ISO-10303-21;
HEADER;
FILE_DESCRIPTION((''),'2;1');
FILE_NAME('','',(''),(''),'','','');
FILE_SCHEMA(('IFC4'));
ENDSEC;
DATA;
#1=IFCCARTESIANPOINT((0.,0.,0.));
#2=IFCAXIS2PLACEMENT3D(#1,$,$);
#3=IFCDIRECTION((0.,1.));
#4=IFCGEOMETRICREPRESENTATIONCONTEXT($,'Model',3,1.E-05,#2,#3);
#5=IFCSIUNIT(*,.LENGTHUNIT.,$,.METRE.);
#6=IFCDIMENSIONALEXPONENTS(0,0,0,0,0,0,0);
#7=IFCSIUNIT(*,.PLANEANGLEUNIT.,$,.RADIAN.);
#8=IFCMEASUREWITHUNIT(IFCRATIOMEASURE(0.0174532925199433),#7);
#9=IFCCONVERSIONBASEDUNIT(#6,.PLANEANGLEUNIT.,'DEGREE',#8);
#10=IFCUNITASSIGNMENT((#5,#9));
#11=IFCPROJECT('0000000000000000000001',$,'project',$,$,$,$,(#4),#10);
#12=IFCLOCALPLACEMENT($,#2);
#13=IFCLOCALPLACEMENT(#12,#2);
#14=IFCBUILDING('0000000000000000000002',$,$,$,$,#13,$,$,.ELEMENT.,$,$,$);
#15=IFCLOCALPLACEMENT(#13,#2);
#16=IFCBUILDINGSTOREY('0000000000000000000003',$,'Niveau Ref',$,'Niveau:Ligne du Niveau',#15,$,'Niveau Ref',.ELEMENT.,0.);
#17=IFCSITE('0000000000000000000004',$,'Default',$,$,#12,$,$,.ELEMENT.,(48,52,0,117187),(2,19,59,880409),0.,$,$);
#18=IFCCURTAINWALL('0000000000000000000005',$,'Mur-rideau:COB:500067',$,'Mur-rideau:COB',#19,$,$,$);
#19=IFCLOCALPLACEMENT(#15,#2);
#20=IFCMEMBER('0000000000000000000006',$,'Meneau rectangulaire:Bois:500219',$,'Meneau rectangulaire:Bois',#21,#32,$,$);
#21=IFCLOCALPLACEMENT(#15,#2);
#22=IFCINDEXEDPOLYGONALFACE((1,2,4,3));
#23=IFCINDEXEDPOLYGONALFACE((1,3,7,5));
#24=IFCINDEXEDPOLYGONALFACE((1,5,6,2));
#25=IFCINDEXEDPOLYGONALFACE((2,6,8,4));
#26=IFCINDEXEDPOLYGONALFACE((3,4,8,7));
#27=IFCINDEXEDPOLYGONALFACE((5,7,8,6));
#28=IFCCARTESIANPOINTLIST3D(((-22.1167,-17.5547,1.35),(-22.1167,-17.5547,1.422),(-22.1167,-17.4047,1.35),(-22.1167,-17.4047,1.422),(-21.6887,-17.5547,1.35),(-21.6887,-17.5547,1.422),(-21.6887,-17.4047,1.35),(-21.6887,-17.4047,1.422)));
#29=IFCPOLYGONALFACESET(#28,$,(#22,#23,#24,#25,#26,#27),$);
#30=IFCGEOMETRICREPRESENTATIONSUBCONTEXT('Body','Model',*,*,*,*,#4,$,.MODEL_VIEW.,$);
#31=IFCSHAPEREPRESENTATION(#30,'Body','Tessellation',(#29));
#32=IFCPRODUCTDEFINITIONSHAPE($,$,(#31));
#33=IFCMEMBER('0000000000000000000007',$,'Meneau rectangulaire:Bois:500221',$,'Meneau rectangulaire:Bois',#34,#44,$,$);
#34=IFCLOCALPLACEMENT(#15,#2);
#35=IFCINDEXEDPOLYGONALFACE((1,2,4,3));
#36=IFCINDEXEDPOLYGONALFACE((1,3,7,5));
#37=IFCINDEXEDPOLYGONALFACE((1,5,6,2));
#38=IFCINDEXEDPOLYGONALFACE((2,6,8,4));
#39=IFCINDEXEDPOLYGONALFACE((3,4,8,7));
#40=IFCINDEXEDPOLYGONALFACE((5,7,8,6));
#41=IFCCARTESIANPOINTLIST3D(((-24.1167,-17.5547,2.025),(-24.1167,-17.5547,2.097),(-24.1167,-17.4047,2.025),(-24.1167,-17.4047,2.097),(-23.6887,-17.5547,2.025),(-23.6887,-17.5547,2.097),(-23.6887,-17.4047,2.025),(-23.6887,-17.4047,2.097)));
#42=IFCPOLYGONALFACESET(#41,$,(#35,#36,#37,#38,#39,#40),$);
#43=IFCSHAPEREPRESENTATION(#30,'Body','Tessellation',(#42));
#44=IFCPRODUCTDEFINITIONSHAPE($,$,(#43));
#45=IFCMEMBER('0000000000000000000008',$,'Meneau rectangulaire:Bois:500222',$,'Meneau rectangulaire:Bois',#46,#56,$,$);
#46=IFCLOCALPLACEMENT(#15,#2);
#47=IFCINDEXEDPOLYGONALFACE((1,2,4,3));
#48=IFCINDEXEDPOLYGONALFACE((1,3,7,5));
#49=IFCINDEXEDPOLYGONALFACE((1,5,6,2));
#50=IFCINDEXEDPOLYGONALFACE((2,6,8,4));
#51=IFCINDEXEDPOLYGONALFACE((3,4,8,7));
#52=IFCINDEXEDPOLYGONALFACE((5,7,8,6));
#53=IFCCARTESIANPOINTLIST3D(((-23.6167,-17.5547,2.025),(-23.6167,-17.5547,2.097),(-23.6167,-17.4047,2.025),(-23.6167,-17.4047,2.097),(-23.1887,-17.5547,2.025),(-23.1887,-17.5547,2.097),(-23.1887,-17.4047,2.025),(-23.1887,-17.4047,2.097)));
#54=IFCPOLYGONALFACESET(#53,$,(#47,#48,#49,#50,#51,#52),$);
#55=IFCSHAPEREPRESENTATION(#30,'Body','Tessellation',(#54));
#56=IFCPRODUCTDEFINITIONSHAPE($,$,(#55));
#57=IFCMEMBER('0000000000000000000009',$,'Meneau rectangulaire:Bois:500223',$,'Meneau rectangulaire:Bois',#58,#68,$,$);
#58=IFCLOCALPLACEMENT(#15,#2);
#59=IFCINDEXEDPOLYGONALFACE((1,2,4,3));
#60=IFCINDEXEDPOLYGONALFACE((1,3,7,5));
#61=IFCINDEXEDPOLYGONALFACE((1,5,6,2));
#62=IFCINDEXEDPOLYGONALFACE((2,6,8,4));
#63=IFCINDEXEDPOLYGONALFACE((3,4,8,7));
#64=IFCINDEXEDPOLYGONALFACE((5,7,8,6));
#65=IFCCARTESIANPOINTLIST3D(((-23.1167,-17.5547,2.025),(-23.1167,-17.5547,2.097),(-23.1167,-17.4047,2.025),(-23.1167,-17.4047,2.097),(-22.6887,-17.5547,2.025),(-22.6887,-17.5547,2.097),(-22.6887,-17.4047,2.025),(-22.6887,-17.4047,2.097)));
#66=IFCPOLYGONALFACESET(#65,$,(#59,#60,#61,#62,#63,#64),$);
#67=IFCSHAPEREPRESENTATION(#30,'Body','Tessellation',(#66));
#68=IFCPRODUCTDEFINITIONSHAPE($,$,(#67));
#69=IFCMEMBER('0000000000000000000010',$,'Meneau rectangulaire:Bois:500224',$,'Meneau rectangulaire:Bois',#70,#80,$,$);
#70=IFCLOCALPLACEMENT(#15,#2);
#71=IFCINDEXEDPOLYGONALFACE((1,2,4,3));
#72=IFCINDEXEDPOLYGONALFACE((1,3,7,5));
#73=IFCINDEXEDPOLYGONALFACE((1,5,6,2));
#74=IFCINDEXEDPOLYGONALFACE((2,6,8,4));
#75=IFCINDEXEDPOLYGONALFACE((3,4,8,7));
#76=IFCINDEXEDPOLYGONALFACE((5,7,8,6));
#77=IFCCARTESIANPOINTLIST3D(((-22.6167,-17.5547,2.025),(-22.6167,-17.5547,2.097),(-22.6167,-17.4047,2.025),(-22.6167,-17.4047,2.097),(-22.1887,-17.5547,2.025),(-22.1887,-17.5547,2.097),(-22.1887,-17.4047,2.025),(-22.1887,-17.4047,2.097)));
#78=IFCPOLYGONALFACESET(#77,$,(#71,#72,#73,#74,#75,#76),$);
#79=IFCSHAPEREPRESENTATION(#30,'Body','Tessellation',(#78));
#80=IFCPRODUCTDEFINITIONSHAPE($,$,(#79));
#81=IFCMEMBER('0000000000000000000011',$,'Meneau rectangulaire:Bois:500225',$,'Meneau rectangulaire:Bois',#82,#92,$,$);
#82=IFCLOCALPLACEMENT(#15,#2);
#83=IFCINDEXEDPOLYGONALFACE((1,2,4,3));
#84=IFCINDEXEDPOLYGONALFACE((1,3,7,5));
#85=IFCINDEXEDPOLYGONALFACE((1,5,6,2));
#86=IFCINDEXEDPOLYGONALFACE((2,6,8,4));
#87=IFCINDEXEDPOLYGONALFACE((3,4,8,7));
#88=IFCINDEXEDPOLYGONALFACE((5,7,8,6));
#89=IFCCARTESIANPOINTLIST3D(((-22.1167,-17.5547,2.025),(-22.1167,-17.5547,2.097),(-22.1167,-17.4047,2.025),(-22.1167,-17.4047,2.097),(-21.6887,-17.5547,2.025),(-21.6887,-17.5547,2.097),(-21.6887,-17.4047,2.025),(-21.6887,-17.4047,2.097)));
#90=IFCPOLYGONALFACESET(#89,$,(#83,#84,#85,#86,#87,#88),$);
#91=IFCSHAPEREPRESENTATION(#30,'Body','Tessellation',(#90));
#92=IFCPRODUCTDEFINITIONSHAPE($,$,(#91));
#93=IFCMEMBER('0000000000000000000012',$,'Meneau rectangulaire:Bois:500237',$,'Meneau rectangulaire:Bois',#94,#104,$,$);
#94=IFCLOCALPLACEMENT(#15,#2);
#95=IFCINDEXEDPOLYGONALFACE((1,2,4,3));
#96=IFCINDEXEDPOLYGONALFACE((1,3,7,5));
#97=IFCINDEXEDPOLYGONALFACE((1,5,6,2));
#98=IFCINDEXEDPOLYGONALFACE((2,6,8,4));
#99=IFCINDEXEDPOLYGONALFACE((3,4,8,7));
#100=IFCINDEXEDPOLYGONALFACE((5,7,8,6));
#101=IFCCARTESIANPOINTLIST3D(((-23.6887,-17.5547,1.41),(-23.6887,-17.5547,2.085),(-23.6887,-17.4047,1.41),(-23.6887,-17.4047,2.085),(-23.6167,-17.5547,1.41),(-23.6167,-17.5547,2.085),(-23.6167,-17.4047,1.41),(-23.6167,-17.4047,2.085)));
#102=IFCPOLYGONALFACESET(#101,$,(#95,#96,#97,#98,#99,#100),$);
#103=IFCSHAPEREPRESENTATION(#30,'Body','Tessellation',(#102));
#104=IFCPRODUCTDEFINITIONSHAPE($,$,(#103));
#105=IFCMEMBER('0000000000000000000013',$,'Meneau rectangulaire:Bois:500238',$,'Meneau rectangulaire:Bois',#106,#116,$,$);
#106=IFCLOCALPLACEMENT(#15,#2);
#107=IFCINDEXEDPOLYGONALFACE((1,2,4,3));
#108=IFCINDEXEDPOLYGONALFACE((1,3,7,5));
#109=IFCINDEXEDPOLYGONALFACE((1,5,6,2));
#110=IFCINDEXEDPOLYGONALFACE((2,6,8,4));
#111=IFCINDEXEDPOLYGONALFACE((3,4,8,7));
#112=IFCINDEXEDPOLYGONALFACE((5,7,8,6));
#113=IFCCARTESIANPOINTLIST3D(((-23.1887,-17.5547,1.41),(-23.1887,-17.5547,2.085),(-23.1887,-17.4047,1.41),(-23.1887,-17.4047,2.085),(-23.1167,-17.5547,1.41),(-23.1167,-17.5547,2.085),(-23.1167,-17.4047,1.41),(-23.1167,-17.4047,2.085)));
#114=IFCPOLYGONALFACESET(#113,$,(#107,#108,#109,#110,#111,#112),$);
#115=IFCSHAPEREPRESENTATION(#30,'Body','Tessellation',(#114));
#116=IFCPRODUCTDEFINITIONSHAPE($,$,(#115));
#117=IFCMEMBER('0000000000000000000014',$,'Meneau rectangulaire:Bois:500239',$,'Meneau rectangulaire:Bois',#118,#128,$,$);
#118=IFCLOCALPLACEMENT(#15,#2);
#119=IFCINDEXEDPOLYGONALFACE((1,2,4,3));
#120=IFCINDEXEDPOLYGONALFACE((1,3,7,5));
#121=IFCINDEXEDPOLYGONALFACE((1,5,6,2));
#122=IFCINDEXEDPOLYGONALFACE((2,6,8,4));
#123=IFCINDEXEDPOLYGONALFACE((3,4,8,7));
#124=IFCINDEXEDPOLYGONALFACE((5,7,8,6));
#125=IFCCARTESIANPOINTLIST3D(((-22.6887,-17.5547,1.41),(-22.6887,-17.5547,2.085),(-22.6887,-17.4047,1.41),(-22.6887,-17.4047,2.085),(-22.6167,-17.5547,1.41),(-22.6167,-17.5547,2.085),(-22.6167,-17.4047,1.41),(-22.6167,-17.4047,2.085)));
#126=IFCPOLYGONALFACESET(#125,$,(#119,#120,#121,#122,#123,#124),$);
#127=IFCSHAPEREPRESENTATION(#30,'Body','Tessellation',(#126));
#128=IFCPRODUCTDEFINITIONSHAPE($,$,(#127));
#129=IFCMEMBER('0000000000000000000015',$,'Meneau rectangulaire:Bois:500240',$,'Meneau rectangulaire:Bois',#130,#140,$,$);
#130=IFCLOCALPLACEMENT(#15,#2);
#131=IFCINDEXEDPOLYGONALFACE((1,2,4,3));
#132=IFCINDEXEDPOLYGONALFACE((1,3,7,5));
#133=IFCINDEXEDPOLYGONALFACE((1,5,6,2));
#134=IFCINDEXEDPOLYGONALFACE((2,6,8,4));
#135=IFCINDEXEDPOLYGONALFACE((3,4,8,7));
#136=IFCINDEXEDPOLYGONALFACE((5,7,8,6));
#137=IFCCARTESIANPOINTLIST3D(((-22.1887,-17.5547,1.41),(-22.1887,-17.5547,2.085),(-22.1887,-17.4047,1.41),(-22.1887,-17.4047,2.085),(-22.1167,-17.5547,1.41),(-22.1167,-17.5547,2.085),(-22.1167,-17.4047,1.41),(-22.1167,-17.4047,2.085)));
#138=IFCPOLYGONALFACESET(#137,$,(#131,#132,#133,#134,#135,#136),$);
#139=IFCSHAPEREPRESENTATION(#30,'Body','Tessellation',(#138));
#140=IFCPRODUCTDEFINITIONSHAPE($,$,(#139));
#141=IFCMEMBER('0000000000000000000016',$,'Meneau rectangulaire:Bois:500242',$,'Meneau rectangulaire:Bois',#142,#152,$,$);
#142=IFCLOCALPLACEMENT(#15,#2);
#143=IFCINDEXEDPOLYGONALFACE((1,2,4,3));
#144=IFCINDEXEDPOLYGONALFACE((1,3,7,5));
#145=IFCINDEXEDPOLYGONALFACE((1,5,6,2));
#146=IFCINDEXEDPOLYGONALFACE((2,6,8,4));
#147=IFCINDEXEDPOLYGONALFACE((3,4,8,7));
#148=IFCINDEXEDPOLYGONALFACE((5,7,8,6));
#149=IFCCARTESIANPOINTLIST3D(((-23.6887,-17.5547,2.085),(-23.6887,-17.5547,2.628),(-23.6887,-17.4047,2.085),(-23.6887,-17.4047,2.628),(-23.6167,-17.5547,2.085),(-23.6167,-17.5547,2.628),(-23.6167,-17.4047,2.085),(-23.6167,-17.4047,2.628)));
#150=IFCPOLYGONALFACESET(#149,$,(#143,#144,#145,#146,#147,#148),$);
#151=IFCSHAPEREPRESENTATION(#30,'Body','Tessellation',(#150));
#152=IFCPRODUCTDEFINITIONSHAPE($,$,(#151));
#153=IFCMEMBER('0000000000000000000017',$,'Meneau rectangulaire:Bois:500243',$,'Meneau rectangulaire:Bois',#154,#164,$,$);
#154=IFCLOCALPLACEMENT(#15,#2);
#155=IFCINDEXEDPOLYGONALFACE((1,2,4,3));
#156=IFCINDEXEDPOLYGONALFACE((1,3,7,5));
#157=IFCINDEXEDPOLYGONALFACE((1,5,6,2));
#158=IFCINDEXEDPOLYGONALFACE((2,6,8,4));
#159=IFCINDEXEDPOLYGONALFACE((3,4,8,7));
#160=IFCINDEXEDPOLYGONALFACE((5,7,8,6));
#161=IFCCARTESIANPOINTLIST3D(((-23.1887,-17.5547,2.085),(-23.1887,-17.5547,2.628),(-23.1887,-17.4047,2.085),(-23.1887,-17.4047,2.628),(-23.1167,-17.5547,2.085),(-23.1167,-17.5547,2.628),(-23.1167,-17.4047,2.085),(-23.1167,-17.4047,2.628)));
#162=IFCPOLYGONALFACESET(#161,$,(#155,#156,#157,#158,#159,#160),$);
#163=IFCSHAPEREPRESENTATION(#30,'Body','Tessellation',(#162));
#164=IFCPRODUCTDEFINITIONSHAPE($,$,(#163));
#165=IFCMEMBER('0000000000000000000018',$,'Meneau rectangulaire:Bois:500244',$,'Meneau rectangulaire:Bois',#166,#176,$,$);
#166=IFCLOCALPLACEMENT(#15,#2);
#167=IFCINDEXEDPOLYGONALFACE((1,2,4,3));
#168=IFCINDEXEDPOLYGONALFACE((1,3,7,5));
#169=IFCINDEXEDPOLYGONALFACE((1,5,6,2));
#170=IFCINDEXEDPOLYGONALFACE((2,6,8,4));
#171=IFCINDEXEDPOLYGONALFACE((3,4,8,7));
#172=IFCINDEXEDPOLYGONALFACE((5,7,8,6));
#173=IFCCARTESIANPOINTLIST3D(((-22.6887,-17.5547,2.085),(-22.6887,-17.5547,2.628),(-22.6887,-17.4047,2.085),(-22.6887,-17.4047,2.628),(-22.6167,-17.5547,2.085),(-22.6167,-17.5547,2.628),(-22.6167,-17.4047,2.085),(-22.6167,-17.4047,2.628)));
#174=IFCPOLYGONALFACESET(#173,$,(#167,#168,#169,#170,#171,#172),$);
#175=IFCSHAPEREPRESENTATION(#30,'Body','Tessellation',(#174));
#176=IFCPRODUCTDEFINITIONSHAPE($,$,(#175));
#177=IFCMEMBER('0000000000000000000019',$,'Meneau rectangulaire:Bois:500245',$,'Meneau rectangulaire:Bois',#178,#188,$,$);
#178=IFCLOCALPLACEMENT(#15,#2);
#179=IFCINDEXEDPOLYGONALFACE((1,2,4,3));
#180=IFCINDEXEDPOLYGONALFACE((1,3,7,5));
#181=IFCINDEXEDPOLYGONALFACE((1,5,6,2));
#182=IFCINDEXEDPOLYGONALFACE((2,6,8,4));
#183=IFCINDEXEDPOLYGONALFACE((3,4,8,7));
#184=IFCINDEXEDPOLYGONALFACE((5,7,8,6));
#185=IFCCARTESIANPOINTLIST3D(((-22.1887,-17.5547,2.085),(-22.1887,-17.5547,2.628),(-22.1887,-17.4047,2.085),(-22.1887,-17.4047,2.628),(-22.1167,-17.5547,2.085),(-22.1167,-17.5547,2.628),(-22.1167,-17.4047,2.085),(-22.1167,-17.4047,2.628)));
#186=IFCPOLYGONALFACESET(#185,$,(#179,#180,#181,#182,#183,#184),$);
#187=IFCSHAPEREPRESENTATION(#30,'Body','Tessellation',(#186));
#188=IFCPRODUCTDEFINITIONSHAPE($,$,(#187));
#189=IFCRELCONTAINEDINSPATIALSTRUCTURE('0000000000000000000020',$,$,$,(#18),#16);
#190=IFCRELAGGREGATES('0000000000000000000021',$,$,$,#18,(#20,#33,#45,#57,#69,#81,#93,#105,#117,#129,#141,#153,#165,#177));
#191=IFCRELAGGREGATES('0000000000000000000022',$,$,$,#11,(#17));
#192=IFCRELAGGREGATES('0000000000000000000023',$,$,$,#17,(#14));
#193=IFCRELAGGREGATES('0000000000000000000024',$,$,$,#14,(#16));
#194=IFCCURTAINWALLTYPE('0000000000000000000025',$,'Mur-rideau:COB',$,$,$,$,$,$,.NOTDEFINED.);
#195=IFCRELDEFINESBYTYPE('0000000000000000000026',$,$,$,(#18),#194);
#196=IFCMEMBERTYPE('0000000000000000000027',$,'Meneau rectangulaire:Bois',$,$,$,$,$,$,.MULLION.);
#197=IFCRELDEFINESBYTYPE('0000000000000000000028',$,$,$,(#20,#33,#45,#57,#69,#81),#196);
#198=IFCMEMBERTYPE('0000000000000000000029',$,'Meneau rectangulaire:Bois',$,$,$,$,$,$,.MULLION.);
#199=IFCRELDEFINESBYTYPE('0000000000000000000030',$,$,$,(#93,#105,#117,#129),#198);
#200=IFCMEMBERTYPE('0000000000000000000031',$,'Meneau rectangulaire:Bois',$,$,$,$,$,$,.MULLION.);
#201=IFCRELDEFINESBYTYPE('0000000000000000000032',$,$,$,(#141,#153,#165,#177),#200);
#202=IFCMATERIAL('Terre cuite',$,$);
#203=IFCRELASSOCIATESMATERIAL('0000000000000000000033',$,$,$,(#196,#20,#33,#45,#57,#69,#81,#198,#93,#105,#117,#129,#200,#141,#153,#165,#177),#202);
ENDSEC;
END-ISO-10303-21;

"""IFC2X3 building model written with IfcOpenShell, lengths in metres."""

from ifc_helpers import new_model, entity, si_unit, converted_unit, direction, frame, origin, origin_2d_with_axis, place, context, subcontext, project, spatial, rectangle, extrude, source, transform, mapped, material, type_object, type_shapes, element, aggregate, save


model = new_model("IFC2X3")

# Units and contexts
model_context = context("Model", 3, precision=1e-05, world=origin(), true_north=direction((0.0, 1.0)))
body_context = subcontext(model_context, "Body", "Model", "MODEL_VIEW")
ifc_project = project(units=[si_unit("LENGTHUNIT", "METRE"), converted_unit("PLANEANGLEUNIT", "DEGREE", entity("IfcRatioMeasure", 0.0174532925199433), si_unit("PLANEANGLEUNIT", "RADIAN"), dimensions=[0, 0, 0, 0, 0, 0, 0])], contexts=[model_context])

# Site, building, storey
site_placement = place(None, origin())
site = spatial("IfcSite", under=ifc_project, at=site_placement, Name="Default", CompositionType="ELEMENT", RefLatitude=(48, 52, 0, 117187), RefLongitude=(2, 19, 59, 880409), RefElevation=0.0)
building_placement = place(site_placement, origin())
building = spatial("IfcBuilding", under=site, at=building_placement, CompositionType="ELEMENT")
storey_placement = place(building_placement, origin())
storey = spatial("IfcBuildingStorey", under=building, at=storey_placement, Name="Niveau Ref", ObjectType="Niveau:Ligne du Niveau", LongName="Niveau Ref", CompositionType="ELEMENT", Elevation=0.0)

# Curtain wall, members
curtain_wall_type = type_object("IfcCurtainWallType", Name="Mur-rideau:COB", PredefinedType="NOTDEFINED")
curtain_wall_placement = place(storey_placement, origin())
curtain_wall = element("IfcCurtainWall", 1, at=curtain_wall_placement, inside=storey, type_object=curtain_wall_type, Name="Mur-rideau:COB:500067", ObjectType="Mur-rideau:COB")
ifc_material = material(Name="Terre cuite")
member_type_1 = type_object("IfcMemberType", Name="Meneau rectangulaire:Bois", PredefinedType="MULLION", material=ifc_material)
shared_shape_1 = source(origin(), body_context, "Body", "SweptSolid", [
    extrude(rectangle(XDim=0.15, YDim=0.072, at=origin_2d_with_axis()), frame((-0.024, 0.0, -0.428), z_axis=(0.0, 0.0, 1.0), x_axis=(0.0, -1.0, 0.0)), (0.0, 0.0, 1.0), 0.428),
])
type_shapes(member_type_1, [shared_shape_1])
member_1_placement = place(storey_placement, frame((-21.6887, -17.4797, 1.41), z_axis=(1.0, 0.0, 0.0), x_axis=(0.0, 0.0, 1.0)))
member_1 = element("IfcMember", 2, at=member_1_placement, type_object=member_type_1, material=ifc_material, Name="Meneau rectangulaire:Bois:500219", ObjectType="Meneau rectangulaire:Bois", context=body_context, shape_type="MappedRepresentation", body=[
    mapped(shared_shape_1, transform((0.0, 0.0, 0.0), scale=1.0)),
])
member_2_placement = place(storey_placement, frame((-23.6887, -17.4797, 2.085), z_axis=(1.0, 0.0, 0.0), x_axis=(0.0, 0.0, 1.0)))
member_2 = element("IfcMember", 3, at=member_2_placement, type_object=member_type_1, material=ifc_material, Name="Meneau rectangulaire:Bois:500221", ObjectType="Meneau rectangulaire:Bois", context=body_context, shape_type="MappedRepresentation", body=[
    mapped(shared_shape_1, transform((0.0, 0.0, 0.0), scale=1.0)),
])
member_3_placement = place(storey_placement, frame((-23.1887, -17.4797, 2.085), z_axis=(1.0, 0.0, 0.0), x_axis=(0.0, 0.0, 1.0)))
member_3 = element("IfcMember", 4, at=member_3_placement, type_object=member_type_1, material=ifc_material, Name="Meneau rectangulaire:Bois:500222", ObjectType="Meneau rectangulaire:Bois", context=body_context, shape_type="MappedRepresentation", body=[
    mapped(shared_shape_1, transform((0.0, 0.0, 0.0), scale=1.0)),
])
member_4_placement = place(storey_placement, frame((-22.6887, -17.4797, 2.085), z_axis=(1.0, 0.0, 0.0), x_axis=(0.0, 0.0, 1.0)))
member_4 = element("IfcMember", 5, at=member_4_placement, type_object=member_type_1, material=ifc_material, Name="Meneau rectangulaire:Bois:500223", ObjectType="Meneau rectangulaire:Bois", context=body_context, shape_type="MappedRepresentation", body=[
    mapped(shared_shape_1, transform((0.0, 0.0, 0.0), scale=1.0)),
])
member_5_placement = place(storey_placement, frame((-22.1887, -17.4797, 2.085), z_axis=(1.0, 0.0, 0.0), x_axis=(0.0, 0.0, 1.0)))
member_5 = element("IfcMember", 6, at=member_5_placement, type_object=member_type_1, material=ifc_material, Name="Meneau rectangulaire:Bois:500224", ObjectType="Meneau rectangulaire:Bois", context=body_context, shape_type="MappedRepresentation", body=[
    mapped(shared_shape_1, transform((0.0, 0.0, 0.0), scale=1.0)),
])
member_6_placement = place(storey_placement, frame((-21.6887, -17.4797, 2.085), z_axis=(1.0, 0.0, 0.0), x_axis=(0.0, 0.0, 1.0)))
member_6 = element("IfcMember", 7, at=member_6_placement, type_object=member_type_1, material=ifc_material, Name="Meneau rectangulaire:Bois:500225", ObjectType="Meneau rectangulaire:Bois", context=body_context, shape_type="MappedRepresentation", body=[
    mapped(shared_shape_1, transform((0.0, 0.0, 0.0), scale=1.0)),
])
member_type_2 = type_object("IfcMemberType", Name="Meneau rectangulaire:Bois", PredefinedType="MULLION", material=ifc_material)
shared_shape_2 = source(origin(), body_context, "Body", "SweptSolid", [
    extrude(rectangle(XDim=0.15, YDim=0.072, at=origin_2d_with_axis()), frame((-0.024, 0.0, -0.675), z_axis=(0.0, 0.0, 1.0), x_axis=(0.0, -1.0, 0.0)), (0.0, 0.0, 1.0), 0.675),
])
type_shapes(member_type_2, [shared_shape_2])
member_7_placement = place(storey_placement, frame((-23.6287, -17.4797, 1.41), z_axis=(0.0, 0.0, -1.0), x_axis=(1.0, 0.0, 0.0)))
member_7 = element("IfcMember", 8, at=member_7_placement, type_object=member_type_2, material=ifc_material, Name="Meneau rectangulaire:Bois:500237", ObjectType="Meneau rectangulaire:Bois", context=body_context, shape_type="MappedRepresentation", body=[
    mapped(shared_shape_2, transform((0.0, 0.0, 0.0), scale=1.0)),
])
member_8_placement = place(storey_placement, frame((-23.1287, -17.4797, 1.41), z_axis=(0.0, 0.0, -1.0), x_axis=(1.0, 0.0, 0.0)))
member_8 = element("IfcMember", 9, at=member_8_placement, type_object=member_type_2, material=ifc_material, Name="Meneau rectangulaire:Bois:500238", ObjectType="Meneau rectangulaire:Bois", context=body_context, shape_type="MappedRepresentation", body=[
    mapped(shared_shape_2, transform((0.0, 0.0, 0.0), scale=1.0)),
])
member_9_placement = place(storey_placement, frame((-22.6287, -17.4797, 1.41), z_axis=(0.0, 0.0, -1.0), x_axis=(1.0, 0.0, 0.0)))
member_9 = element("IfcMember", 10, at=member_9_placement, type_object=member_type_2, material=ifc_material, Name="Meneau rectangulaire:Bois:500239", ObjectType="Meneau rectangulaire:Bois", context=body_context, shape_type="MappedRepresentation", body=[
    mapped(shared_shape_2, transform((0.0, 0.0, 0.0), scale=1.0)),
])
member_10_placement = place(storey_placement, frame((-22.1287, -17.4797, 1.41), z_axis=(0.0, 0.0, -1.0), x_axis=(1.0, 0.0, 0.0)))
member_10 = element("IfcMember", 11, at=member_10_placement, type_object=member_type_2, material=ifc_material, Name="Meneau rectangulaire:Bois:500240", ObjectType="Meneau rectangulaire:Bois", context=body_context, shape_type="MappedRepresentation", body=[
    mapped(shared_shape_2, transform((0.0, 0.0, 0.0), scale=1.0)),
])
member_type_3 = type_object("IfcMemberType", Name="Meneau rectangulaire:Bois", PredefinedType="MULLION", material=ifc_material)
shared_shape_3 = source(origin(), body_context, "Body", "SweptSolid", [
    extrude(rectangle(XDim=0.15, YDim=0.072, at=origin_2d_with_axis()), frame((-0.024, 0.0, -0.543), z_axis=(0.0, 0.0, 1.0), x_axis=(0.0, -1.0, 0.0)), (0.0, 0.0, 1.0), 0.543),
])
type_shapes(member_type_3, [shared_shape_3])
member_11_placement = place(storey_placement, frame((-23.6287, -17.4797, 2.085), z_axis=(0.0, 0.0, -1.0), x_axis=(1.0, 0.0, 0.0)))
member_11 = element("IfcMember", 12, at=member_11_placement, type_object=member_type_3, material=ifc_material, Name="Meneau rectangulaire:Bois:500242", ObjectType="Meneau rectangulaire:Bois", context=body_context, shape_type="MappedRepresentation", body=[
    mapped(shared_shape_3, transform((0.0, 0.0, 0.0), scale=1.0)),
])
member_12_placement = place(storey_placement, frame((-23.1287, -17.4797, 2.085), z_axis=(0.0, 0.0, -1.0), x_axis=(1.0, 0.0, 0.0)))
member_12 = element("IfcMember", 13, at=member_12_placement, type_object=member_type_3, material=ifc_material, Name="Meneau rectangulaire:Bois:500243", ObjectType="Meneau rectangulaire:Bois", context=body_context, shape_type="MappedRepresentation", body=[
    mapped(shared_shape_3, transform((0.0, 0.0, 0.0), scale=1.0)),
])
member_13_placement = place(storey_placement, frame((-22.6287, -17.4797, 2.085), z_axis=(0.0, 0.0, -1.0), x_axis=(1.0, 0.0, 0.0)))
member_13 = element("IfcMember", 14, at=member_13_placement, type_object=member_type_3, material=ifc_material, Name="Meneau rectangulaire:Bois:500244", ObjectType="Meneau rectangulaire:Bois", context=body_context, shape_type="MappedRepresentation", body=[
    mapped(shared_shape_3, transform((0.0, 0.0, 0.0), scale=1.0)),
])
member_14_placement = place(storey_placement, frame((-22.1287, -17.4797, 2.085), z_axis=(0.0, 0.0, -1.0), x_axis=(1.0, 0.0, 0.0)))
member_14 = element("IfcMember", 15, at=member_14_placement, type_object=member_type_3, material=ifc_material, Name="Meneau rectangulaire:Bois:500245", ObjectType="Meneau rectangulaire:Bois", context=body_context, shape_type="MappedRepresentation", body=[
    mapped(shared_shape_3, transform((0.0, 0.0, 0.0), scale=1.0)),
])
aggregate(curtain_wall, [member_1, member_2, member_3, member_4, member_5, member_6, member_7, member_8, member_9, member_10, member_11, member_12, member_13, member_14])

save(model, "model.ifc")
